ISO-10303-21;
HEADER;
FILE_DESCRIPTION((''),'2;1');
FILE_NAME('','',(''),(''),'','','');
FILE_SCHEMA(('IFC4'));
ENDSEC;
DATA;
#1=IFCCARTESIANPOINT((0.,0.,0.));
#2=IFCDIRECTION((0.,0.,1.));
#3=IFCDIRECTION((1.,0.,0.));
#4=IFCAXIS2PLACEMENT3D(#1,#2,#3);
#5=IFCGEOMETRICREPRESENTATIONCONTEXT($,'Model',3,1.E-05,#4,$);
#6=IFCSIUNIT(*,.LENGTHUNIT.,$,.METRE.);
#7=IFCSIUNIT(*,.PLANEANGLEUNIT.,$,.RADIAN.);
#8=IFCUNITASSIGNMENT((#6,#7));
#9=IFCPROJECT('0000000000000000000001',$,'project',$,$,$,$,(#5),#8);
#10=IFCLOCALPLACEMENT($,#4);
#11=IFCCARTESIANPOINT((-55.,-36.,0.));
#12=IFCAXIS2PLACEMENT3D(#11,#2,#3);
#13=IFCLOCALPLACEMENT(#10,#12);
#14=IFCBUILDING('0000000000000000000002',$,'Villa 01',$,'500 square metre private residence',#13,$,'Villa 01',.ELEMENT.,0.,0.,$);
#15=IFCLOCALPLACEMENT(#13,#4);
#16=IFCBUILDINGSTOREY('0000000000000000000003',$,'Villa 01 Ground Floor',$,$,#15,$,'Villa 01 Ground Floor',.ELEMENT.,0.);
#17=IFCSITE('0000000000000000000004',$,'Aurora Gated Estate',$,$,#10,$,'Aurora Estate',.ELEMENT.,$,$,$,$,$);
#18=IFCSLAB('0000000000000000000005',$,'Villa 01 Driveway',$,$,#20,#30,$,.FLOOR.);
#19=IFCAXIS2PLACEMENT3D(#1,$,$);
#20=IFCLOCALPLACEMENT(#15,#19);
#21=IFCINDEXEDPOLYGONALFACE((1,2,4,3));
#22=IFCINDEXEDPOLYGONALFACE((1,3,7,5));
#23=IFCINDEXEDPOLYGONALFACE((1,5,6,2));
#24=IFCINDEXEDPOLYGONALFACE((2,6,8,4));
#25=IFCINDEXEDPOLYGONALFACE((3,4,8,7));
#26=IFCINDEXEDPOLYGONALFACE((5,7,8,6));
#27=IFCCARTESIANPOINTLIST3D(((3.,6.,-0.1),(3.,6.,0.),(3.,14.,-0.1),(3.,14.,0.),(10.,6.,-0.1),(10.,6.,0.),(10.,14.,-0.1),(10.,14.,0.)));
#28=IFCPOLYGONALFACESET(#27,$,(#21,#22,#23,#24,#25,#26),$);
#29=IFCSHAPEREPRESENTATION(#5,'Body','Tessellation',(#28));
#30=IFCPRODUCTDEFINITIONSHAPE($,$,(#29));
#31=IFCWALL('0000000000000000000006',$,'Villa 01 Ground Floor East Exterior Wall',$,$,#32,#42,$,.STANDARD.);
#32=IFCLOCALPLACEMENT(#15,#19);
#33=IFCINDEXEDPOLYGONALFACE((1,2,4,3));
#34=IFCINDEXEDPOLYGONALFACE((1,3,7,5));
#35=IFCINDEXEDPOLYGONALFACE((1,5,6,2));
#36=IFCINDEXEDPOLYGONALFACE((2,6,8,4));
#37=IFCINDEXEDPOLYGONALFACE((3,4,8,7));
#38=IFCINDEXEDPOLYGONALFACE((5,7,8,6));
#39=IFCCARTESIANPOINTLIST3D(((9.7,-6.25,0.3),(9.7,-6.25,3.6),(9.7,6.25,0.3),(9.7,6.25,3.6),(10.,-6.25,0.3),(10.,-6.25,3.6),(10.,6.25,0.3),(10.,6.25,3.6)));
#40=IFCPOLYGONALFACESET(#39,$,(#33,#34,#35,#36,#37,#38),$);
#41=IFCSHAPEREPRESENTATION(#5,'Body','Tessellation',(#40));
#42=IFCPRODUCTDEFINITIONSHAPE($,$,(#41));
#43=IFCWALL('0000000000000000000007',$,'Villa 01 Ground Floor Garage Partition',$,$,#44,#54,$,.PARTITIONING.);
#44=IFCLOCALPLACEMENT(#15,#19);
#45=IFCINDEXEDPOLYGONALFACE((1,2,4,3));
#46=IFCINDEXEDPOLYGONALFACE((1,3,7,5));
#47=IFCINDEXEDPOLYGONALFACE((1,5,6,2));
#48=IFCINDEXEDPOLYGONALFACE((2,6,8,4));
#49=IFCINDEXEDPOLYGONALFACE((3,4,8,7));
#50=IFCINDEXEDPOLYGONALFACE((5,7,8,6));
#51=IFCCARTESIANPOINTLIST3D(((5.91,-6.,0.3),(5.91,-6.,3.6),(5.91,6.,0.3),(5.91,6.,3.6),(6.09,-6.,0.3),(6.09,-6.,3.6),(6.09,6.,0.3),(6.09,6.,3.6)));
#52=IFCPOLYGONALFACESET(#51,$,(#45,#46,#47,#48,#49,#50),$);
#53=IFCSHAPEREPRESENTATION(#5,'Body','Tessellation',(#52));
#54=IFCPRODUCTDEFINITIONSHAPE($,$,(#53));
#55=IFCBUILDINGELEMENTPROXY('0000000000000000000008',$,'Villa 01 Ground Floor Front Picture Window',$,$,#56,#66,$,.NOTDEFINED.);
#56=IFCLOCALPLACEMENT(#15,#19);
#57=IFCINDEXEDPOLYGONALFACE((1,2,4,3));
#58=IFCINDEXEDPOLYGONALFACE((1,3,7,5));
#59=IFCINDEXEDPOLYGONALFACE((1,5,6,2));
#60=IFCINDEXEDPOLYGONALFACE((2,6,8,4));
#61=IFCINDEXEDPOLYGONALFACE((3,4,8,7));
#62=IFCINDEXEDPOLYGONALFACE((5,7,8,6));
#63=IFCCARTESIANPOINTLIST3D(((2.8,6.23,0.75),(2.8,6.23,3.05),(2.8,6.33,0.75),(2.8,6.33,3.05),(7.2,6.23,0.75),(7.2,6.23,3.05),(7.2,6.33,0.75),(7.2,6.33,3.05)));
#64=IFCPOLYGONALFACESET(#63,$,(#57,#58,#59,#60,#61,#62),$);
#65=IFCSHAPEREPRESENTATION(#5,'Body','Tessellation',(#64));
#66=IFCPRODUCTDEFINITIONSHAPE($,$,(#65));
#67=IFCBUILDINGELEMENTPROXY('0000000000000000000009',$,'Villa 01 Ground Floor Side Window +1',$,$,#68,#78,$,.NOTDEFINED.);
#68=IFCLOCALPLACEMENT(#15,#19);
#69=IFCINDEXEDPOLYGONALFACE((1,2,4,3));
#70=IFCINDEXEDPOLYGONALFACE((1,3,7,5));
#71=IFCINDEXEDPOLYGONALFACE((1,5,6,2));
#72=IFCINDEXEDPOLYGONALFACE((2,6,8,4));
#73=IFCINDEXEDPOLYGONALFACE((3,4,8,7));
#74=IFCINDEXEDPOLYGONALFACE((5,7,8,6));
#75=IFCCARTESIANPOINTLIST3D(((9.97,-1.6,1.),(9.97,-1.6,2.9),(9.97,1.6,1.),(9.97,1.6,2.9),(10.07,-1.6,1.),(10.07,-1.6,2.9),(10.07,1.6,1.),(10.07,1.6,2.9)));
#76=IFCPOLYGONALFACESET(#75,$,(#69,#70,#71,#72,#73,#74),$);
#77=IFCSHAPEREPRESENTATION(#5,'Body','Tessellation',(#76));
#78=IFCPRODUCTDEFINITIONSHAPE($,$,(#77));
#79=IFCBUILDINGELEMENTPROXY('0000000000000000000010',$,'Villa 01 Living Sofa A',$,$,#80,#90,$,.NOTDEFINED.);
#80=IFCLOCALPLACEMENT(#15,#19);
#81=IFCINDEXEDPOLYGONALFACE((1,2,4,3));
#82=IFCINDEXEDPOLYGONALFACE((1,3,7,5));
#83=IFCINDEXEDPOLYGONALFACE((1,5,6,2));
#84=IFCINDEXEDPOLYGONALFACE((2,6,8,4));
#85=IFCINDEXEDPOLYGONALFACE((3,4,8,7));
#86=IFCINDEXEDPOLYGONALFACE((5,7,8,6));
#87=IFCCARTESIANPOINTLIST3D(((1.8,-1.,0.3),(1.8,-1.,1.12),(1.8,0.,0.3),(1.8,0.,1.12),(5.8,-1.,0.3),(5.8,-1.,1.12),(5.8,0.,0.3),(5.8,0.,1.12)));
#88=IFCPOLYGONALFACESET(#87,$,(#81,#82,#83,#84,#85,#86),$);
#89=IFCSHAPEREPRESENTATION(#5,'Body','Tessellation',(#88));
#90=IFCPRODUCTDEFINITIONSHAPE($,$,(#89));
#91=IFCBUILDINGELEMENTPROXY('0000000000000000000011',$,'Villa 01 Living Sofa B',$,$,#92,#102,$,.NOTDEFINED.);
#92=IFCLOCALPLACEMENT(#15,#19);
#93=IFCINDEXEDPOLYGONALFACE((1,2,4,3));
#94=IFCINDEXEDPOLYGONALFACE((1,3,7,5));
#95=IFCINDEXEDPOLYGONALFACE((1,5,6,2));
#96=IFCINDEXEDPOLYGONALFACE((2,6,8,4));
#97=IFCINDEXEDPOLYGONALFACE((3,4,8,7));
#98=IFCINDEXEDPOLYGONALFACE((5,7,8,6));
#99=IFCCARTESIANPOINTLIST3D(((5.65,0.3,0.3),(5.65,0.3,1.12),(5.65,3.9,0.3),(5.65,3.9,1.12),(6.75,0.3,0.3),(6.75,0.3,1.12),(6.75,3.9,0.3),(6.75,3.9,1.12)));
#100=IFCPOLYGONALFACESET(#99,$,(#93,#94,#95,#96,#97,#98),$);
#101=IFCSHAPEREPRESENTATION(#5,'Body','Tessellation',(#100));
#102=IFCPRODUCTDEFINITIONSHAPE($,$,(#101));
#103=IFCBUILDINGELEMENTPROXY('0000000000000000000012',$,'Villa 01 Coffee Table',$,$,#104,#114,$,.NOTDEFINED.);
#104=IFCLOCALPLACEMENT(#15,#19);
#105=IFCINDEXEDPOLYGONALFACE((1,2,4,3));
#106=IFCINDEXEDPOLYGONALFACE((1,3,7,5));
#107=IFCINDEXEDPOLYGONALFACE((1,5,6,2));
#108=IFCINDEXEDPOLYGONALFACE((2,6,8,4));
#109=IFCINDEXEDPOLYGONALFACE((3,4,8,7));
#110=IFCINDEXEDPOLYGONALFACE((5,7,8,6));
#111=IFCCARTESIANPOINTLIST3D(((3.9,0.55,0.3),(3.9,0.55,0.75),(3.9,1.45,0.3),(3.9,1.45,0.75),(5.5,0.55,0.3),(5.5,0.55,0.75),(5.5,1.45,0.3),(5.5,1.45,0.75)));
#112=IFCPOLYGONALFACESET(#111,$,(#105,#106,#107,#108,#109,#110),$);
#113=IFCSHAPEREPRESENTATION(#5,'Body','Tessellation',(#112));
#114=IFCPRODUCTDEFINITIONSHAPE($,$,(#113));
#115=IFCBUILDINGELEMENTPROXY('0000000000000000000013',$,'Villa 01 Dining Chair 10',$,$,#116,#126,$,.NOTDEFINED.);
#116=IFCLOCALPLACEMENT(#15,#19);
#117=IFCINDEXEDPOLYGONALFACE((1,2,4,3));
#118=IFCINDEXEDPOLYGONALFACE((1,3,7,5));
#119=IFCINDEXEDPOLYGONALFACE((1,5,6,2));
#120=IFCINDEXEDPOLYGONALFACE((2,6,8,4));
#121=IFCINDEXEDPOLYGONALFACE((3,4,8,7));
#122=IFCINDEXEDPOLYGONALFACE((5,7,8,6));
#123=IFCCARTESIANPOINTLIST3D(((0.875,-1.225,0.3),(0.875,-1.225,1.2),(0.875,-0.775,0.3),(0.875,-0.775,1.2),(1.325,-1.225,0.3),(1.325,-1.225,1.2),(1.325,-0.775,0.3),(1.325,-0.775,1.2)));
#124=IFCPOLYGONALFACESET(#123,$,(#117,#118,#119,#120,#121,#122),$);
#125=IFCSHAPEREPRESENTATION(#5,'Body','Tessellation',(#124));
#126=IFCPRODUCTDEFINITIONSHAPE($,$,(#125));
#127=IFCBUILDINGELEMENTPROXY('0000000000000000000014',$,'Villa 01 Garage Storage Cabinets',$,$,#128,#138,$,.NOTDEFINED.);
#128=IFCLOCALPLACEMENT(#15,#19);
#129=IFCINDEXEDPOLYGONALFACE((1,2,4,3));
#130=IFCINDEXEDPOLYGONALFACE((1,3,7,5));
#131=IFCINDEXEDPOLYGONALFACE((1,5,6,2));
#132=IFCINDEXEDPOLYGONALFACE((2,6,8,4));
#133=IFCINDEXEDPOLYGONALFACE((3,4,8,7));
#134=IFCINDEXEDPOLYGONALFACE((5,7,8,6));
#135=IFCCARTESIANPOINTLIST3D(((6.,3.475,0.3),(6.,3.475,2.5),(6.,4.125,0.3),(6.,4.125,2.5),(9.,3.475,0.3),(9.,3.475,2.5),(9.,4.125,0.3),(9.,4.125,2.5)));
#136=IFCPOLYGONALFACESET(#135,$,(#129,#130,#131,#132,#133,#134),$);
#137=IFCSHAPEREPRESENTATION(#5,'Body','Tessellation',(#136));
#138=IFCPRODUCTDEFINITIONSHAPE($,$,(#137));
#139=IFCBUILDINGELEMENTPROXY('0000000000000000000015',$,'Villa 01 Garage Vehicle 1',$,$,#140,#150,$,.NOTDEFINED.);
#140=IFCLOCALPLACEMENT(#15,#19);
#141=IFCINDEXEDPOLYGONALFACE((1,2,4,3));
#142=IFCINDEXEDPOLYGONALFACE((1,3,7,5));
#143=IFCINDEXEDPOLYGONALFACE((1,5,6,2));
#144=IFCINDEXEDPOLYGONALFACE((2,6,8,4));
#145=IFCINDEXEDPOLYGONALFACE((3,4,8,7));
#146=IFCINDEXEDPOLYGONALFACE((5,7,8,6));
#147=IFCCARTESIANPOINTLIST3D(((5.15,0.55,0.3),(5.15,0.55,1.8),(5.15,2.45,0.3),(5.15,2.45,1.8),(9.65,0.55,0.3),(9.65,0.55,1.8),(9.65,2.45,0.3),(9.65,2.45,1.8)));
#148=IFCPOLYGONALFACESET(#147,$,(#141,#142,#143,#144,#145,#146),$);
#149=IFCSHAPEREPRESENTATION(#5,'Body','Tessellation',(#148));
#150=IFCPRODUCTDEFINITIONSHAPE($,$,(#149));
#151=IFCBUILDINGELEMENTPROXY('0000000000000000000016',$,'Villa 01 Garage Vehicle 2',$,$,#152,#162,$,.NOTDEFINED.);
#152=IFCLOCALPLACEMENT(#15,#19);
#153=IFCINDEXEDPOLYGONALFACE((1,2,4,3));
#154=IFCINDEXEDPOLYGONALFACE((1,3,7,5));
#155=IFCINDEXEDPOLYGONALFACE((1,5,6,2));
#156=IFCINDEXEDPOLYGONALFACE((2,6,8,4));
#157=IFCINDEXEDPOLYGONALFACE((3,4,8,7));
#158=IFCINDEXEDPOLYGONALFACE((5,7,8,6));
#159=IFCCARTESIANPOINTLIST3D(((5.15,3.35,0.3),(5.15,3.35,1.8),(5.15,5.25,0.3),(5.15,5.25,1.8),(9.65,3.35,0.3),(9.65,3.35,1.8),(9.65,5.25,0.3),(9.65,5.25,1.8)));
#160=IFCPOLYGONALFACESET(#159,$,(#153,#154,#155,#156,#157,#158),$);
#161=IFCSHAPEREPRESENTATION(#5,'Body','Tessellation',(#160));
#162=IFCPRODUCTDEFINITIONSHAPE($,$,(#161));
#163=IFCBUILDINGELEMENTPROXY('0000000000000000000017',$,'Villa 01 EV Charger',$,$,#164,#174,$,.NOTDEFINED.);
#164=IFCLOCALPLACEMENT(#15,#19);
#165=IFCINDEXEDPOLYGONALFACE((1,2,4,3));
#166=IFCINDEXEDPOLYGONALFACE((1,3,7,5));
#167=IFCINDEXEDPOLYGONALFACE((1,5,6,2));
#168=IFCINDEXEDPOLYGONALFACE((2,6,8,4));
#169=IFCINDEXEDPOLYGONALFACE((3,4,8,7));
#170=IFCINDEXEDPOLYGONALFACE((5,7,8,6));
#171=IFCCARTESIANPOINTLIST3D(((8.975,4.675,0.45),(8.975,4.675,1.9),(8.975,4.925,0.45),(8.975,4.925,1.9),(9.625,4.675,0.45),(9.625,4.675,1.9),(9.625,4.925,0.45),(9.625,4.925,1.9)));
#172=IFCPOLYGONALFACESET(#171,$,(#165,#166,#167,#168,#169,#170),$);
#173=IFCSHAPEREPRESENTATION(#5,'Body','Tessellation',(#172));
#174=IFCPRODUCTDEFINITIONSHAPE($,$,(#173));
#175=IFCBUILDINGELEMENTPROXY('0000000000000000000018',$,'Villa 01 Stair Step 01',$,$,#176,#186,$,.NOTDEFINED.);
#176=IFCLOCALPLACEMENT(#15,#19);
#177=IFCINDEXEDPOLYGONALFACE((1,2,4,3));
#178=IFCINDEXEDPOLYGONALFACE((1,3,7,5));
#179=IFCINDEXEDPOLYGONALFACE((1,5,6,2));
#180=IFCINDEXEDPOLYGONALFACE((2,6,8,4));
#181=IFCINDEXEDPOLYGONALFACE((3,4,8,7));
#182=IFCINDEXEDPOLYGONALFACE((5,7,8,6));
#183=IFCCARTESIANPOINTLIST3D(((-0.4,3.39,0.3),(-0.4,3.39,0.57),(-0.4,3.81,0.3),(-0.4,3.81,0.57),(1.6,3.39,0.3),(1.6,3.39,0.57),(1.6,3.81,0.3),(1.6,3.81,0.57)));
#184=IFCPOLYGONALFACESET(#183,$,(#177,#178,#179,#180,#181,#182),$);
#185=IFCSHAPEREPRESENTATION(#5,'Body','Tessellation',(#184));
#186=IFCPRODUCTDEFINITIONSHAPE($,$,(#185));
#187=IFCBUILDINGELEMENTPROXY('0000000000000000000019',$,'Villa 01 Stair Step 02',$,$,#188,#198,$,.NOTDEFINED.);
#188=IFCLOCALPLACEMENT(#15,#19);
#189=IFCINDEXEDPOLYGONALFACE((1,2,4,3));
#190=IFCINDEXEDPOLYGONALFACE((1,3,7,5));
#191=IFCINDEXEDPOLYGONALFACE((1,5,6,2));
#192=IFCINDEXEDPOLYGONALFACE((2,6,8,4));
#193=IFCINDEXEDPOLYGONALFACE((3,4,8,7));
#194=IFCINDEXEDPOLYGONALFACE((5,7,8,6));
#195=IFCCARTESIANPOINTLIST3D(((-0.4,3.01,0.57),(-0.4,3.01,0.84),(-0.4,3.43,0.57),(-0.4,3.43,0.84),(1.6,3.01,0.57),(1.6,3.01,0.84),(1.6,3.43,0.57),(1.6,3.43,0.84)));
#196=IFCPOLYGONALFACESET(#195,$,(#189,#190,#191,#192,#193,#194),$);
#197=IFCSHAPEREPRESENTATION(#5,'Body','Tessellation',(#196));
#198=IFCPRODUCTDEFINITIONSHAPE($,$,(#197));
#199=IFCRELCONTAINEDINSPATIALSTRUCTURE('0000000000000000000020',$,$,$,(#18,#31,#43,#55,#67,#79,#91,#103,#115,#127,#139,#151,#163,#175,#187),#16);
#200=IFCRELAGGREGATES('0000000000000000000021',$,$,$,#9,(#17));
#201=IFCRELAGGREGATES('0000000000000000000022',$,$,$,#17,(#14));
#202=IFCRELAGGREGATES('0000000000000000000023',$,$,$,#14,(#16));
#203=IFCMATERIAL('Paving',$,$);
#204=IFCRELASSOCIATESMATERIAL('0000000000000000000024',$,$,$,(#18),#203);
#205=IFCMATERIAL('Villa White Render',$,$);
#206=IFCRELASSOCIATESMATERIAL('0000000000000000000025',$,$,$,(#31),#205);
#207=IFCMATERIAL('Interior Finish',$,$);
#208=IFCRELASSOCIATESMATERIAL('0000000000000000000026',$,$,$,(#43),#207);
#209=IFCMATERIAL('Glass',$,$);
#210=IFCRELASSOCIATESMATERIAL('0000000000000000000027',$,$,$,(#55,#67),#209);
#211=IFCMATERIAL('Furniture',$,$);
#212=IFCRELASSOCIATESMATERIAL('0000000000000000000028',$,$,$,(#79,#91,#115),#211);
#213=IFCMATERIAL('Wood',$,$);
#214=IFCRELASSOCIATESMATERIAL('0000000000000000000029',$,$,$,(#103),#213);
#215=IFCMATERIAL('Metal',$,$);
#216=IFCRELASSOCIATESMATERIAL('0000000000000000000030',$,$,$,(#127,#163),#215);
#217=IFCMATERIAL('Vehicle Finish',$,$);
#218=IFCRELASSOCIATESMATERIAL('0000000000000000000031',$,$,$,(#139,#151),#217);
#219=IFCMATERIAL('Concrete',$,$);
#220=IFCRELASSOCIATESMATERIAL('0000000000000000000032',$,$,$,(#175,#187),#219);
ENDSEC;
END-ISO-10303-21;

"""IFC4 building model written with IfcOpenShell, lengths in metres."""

from ifc_helpers import new_model, si_unit, frame, origin_with_axes, origin_2d_with_axis, place, context, project, spatial, rectangle, extrude, material, element, save


model = new_model("IFC4")

# Units and contexts
model_context = context("Model", 3, precision=1e-05, world=origin_with_axes())
ifc_project = project(units=[si_unit("LENGTHUNIT", "METRE"), si_unit("PLANEANGLEUNIT", "RADIAN")], contexts=[model_context])

# Site, building, storey
site_placement = place(None, origin_with_axes())
site = spatial("IfcSite", under=ifc_project, at=site_placement, Name="Aurora Gated Estate", LongName="Aurora Estate", CompositionType="ELEMENT")
building_placement = place(site_placement, frame((-55.0, -36.0, 0.0), z_axis=(0.0, 0.0, 1.0), x_axis=(1.0, 0.0, 0.0)))
building = spatial("IfcBuilding", under=site, at=building_placement, Name="Villa 01", ObjectType="500 square metre private residence", LongName="Villa 01", CompositionType="ELEMENT", ElevationOfRefHeight=0.0, ElevationOfTerrain=0.0)
storey_placement = place(building_placement, origin_with_axes())
storey = spatial("IfcBuildingStorey", under=building, at=storey_placement, Name="Villa 01 Ground Floor", LongName="Villa 01 Ground Floor", CompositionType="ELEMENT", Elevation=0.0)

# Slab
ifc_material_1 = material(Name="Paving")
slab_placement = place(storey_placement, frame((6.5, 10.0, -0.1), z_axis=(0.0, 0.0, 1.0), x_axis=(1.0, 0.0, 0.0)))
element("IfcSlab", 1, at=slab_placement, inside=storey, material=ifc_material_1, Name="Villa 01 Driveway", PredefinedType="FLOOR", context=model_context, shape_type="SweptSolid", body=[
    extrude(rectangle(XDim=7.0, YDim=8.0, at=origin_2d_with_axis()), origin_with_axes(), (0.0, 0.0, 1.0), 0.1),
])

# Walls
ifc_material_2 = material(Name="Villa White Render")
wall_1_placement = place(storey_placement, frame((9.85, 0.0, 0.3), z_axis=(0.0, 0.0, 1.0), x_axis=(1.0, 0.0, 0.0)))
element("IfcWall", 2, at=wall_1_placement, inside=storey, material=ifc_material_2, Name="Villa 01 Ground Floor East Exterior Wall", PredefinedType="STANDARD", context=model_context, shape_type="SweptSolid", body=[
    extrude(rectangle(XDim=0.3, YDim=12.5, at=origin_2d_with_axis()), origin_with_axes(), (0.0, 0.0, 1.0), 3.3),
])
ifc_material_3 = material(Name="Interior Finish")
wall_2_placement = place(storey_placement, frame((6.0, 0.0, 0.3), z_axis=(0.0, 0.0, 1.0), x_axis=(1.0, 0.0, 0.0)))
element("IfcWall", 3, at=wall_2_placement, inside=storey, material=ifc_material_3, Name="Villa 01 Ground Floor Garage Partition", PredefinedType="PARTITIONING", context=model_context, shape_type="SweptSolid", body=[
    extrude(rectangle(XDim=0.18, YDim=12.0, at=origin_2d_with_axis()), origin_with_axes(), (0.0, 0.0, 1.0), 3.3),
])

# Building element proxies
ifc_material_4 = material(Name="Glass")
proxy_1_placement = place(storey_placement, frame((5.0, 6.28, 0.75), z_axis=(0.0, 0.0, 1.0), x_axis=(1.0, 0.0, 0.0)))
element("IfcBuildingElementProxy", 4, at=proxy_1_placement, inside=storey, material=ifc_material_4, Name="Villa 01 Ground Floor Front Picture Window", PredefinedType="NOTDEFINED", context=model_context, shape_type="SweptSolid", body=[
    extrude(rectangle(XDim=4.4, YDim=0.1, at=origin_2d_with_axis()), origin_with_axes(), (0.0, 0.0, 1.0), 2.3),
])
proxy_2_placement = place(storey_placement, frame((10.02, 0.0, 1.0), z_axis=(0.0, 0.0, 1.0), x_axis=(0.0, 1.0, 0.0)))
element("IfcBuildingElementProxy", 5, at=proxy_2_placement, inside=storey, material=ifc_material_4, Name="Villa 01 Ground Floor Side Window +1", PredefinedType="NOTDEFINED", context=model_context, shape_type="SweptSolid", body=[
    extrude(rectangle(XDim=3.2, YDim=0.1, at=origin_2d_with_axis()), origin_with_axes(), (0.0, 0.0, 1.0), 1.9),
])
ifc_material_5 = material(Name="Furniture")
proxy_3_placement = place(storey_placement, frame((3.8, -0.5, 0.3), z_axis=(0.0, 0.0, 1.0), x_axis=(1.0, 0.0, 0.0)))
element("IfcBuildingElementProxy", 6, at=proxy_3_placement, inside=storey, material=ifc_material_5, Name="Villa 01 Living Sofa A", PredefinedType="NOTDEFINED", context=model_context, shape_type="SweptSolid", body=[
    extrude(rectangle(XDim=4.0, YDim=1.0, at=origin_2d_with_axis()), origin_with_axes(), (0.0, 0.0, 1.0), 0.82),
])
proxy_4_placement = place(storey_placement, frame((6.2, 2.1, 0.3), z_axis=(0.0, 0.0, 1.0), x_axis=(1.0, 0.0, 0.0)))
element("IfcBuildingElementProxy", 7, at=proxy_4_placement, inside=storey, material=ifc_material_5, Name="Villa 01 Living Sofa B", PredefinedType="NOTDEFINED", context=model_context, shape_type="SweptSolid", body=[
    extrude(rectangle(XDim=1.1, YDim=3.6, at=origin_2d_with_axis()), origin_with_axes(), (0.0, 0.0, 1.0), 0.82),
])
ifc_material_6 = material(Name="Wood")
proxy_5_placement = place(storey_placement, frame((4.7, 1.0, 0.3), z_axis=(0.0, 0.0, 1.0), x_axis=(1.0, 0.0, 0.0)))
element("IfcBuildingElementProxy", 8, at=proxy_5_placement, inside=storey, material=ifc_material_6, Name="Villa 01 Coffee Table", PredefinedType="NOTDEFINED", context=model_context, shape_type="SweptSolid", body=[
    extrude(rectangle(XDim=1.6, YDim=0.9, at=origin_2d_with_axis()), origin_with_axes(), (0.0, 0.0, 1.0), 0.45),
])
proxy_6_placement = place(storey_placement, frame((1.1, -1.0, 0.3), z_axis=(0.0, 0.0, 1.0), x_axis=(1.0, 0.0, 0.0)))
element("IfcBuildingElementProxy", 9, at=proxy_6_placement, inside=storey, material=ifc_material_5, Name="Villa 01 Dining Chair 10", PredefinedType="NOTDEFINED", context=model_context, shape_type="SweptSolid", body=[
    extrude(rectangle(XDim=0.45, YDim=0.45, at=origin_2d_with_axis()), origin_with_axes(), (0.0, 0.0, 1.0), 0.9),
])
ifc_material_7 = material(Name="Metal")
proxy_7_placement = place(storey_placement, frame((7.5, 3.8, 0.3), z_axis=(0.0, 0.0, 1.0), x_axis=(1.0, 0.0, 0.0)))
element("IfcBuildingElementProxy", 10, at=proxy_7_placement, inside=storey, material=ifc_material_7, Name="Villa 01 Garage Storage Cabinets", PredefinedType="NOTDEFINED", context=model_context, shape_type="SweptSolid", body=[
    extrude(rectangle(XDim=3.0, YDim=0.65, at=origin_2d_with_axis()), origin_with_axes(), (0.0, 0.0, 1.0), 2.2),
])
ifc_material_8 = material(Name="Vehicle Finish")
for number, where, z_axis, x_axis, name in (
    (11, (7.4, 1.5, 0.3), (0.0, 0.0, 1.0), (1.0, 0.0, 0.0), "Villa 01 Garage Vehicle 1"),
    (12, (7.4, 4.3, 0.3), (0.0, 0.0, 1.0), (1.0, 0.0, 0.0), "Villa 01 Garage Vehicle 2"),
):
    element("IfcBuildingElementProxy", number, at=place(storey_placement, frame(where, z_axis=z_axis, x_axis=x_axis)), inside=storey, material=ifc_material_8, Name=name, PredefinedType="NOTDEFINED", context=model_context, shape_type="SweptSolid", body=[
        extrude(rectangle(XDim=4.5, YDim=1.9, at=origin_2d_with_axis()), origin_with_axes(), (0.0, 0.0, 1.0), 1.5),
    ])
proxy_8_placement = place(storey_placement, frame((9.3, 4.8, 0.45), z_axis=(0.0, 0.0, 1.0), x_axis=(1.0, 0.0, 0.0)))
element("IfcBuildingElementProxy", 13, at=proxy_8_placement, inside=storey, material=ifc_material_7, Name="Villa 01 EV Charger", PredefinedType="NOTDEFINED", context=model_context, shape_type="SweptSolid", body=[
    extrude(rectangle(XDim=0.65, YDim=0.25, at=origin_2d_with_axis()), origin_with_axes(), (0.0, 0.0, 1.0), 1.45),
])
ifc_material_9 = material(Name="Concrete")
for number, where, z_axis, x_axis, name in (
    (14, (0.6, 3.6, 0.3), (0.0, 0.0, 1.0), (1.0, 0.0, 0.0), "Villa 01 Stair Step 01"),
    (15, (0.6, 3.22, 0.57), (0.0, 0.0, 1.0), (1.0, 0.0, 0.0), "Villa 01 Stair Step 02"),
):
    element("IfcBuildingElementProxy", number, at=place(storey_placement, frame(where, z_axis=z_axis, x_axis=x_axis)), inside=storey, material=ifc_material_9, Name=name, PredefinedType="NOTDEFINED", context=model_context, shape_type="SweptSolid", body=[
        extrude(rectangle(XDim=2.0, YDim=0.42, at=origin_2d_with_axis()), origin_with_axes(), (0.0, 0.0, 1.0), 0.27),
    ])

save(model, "model.ifc")
